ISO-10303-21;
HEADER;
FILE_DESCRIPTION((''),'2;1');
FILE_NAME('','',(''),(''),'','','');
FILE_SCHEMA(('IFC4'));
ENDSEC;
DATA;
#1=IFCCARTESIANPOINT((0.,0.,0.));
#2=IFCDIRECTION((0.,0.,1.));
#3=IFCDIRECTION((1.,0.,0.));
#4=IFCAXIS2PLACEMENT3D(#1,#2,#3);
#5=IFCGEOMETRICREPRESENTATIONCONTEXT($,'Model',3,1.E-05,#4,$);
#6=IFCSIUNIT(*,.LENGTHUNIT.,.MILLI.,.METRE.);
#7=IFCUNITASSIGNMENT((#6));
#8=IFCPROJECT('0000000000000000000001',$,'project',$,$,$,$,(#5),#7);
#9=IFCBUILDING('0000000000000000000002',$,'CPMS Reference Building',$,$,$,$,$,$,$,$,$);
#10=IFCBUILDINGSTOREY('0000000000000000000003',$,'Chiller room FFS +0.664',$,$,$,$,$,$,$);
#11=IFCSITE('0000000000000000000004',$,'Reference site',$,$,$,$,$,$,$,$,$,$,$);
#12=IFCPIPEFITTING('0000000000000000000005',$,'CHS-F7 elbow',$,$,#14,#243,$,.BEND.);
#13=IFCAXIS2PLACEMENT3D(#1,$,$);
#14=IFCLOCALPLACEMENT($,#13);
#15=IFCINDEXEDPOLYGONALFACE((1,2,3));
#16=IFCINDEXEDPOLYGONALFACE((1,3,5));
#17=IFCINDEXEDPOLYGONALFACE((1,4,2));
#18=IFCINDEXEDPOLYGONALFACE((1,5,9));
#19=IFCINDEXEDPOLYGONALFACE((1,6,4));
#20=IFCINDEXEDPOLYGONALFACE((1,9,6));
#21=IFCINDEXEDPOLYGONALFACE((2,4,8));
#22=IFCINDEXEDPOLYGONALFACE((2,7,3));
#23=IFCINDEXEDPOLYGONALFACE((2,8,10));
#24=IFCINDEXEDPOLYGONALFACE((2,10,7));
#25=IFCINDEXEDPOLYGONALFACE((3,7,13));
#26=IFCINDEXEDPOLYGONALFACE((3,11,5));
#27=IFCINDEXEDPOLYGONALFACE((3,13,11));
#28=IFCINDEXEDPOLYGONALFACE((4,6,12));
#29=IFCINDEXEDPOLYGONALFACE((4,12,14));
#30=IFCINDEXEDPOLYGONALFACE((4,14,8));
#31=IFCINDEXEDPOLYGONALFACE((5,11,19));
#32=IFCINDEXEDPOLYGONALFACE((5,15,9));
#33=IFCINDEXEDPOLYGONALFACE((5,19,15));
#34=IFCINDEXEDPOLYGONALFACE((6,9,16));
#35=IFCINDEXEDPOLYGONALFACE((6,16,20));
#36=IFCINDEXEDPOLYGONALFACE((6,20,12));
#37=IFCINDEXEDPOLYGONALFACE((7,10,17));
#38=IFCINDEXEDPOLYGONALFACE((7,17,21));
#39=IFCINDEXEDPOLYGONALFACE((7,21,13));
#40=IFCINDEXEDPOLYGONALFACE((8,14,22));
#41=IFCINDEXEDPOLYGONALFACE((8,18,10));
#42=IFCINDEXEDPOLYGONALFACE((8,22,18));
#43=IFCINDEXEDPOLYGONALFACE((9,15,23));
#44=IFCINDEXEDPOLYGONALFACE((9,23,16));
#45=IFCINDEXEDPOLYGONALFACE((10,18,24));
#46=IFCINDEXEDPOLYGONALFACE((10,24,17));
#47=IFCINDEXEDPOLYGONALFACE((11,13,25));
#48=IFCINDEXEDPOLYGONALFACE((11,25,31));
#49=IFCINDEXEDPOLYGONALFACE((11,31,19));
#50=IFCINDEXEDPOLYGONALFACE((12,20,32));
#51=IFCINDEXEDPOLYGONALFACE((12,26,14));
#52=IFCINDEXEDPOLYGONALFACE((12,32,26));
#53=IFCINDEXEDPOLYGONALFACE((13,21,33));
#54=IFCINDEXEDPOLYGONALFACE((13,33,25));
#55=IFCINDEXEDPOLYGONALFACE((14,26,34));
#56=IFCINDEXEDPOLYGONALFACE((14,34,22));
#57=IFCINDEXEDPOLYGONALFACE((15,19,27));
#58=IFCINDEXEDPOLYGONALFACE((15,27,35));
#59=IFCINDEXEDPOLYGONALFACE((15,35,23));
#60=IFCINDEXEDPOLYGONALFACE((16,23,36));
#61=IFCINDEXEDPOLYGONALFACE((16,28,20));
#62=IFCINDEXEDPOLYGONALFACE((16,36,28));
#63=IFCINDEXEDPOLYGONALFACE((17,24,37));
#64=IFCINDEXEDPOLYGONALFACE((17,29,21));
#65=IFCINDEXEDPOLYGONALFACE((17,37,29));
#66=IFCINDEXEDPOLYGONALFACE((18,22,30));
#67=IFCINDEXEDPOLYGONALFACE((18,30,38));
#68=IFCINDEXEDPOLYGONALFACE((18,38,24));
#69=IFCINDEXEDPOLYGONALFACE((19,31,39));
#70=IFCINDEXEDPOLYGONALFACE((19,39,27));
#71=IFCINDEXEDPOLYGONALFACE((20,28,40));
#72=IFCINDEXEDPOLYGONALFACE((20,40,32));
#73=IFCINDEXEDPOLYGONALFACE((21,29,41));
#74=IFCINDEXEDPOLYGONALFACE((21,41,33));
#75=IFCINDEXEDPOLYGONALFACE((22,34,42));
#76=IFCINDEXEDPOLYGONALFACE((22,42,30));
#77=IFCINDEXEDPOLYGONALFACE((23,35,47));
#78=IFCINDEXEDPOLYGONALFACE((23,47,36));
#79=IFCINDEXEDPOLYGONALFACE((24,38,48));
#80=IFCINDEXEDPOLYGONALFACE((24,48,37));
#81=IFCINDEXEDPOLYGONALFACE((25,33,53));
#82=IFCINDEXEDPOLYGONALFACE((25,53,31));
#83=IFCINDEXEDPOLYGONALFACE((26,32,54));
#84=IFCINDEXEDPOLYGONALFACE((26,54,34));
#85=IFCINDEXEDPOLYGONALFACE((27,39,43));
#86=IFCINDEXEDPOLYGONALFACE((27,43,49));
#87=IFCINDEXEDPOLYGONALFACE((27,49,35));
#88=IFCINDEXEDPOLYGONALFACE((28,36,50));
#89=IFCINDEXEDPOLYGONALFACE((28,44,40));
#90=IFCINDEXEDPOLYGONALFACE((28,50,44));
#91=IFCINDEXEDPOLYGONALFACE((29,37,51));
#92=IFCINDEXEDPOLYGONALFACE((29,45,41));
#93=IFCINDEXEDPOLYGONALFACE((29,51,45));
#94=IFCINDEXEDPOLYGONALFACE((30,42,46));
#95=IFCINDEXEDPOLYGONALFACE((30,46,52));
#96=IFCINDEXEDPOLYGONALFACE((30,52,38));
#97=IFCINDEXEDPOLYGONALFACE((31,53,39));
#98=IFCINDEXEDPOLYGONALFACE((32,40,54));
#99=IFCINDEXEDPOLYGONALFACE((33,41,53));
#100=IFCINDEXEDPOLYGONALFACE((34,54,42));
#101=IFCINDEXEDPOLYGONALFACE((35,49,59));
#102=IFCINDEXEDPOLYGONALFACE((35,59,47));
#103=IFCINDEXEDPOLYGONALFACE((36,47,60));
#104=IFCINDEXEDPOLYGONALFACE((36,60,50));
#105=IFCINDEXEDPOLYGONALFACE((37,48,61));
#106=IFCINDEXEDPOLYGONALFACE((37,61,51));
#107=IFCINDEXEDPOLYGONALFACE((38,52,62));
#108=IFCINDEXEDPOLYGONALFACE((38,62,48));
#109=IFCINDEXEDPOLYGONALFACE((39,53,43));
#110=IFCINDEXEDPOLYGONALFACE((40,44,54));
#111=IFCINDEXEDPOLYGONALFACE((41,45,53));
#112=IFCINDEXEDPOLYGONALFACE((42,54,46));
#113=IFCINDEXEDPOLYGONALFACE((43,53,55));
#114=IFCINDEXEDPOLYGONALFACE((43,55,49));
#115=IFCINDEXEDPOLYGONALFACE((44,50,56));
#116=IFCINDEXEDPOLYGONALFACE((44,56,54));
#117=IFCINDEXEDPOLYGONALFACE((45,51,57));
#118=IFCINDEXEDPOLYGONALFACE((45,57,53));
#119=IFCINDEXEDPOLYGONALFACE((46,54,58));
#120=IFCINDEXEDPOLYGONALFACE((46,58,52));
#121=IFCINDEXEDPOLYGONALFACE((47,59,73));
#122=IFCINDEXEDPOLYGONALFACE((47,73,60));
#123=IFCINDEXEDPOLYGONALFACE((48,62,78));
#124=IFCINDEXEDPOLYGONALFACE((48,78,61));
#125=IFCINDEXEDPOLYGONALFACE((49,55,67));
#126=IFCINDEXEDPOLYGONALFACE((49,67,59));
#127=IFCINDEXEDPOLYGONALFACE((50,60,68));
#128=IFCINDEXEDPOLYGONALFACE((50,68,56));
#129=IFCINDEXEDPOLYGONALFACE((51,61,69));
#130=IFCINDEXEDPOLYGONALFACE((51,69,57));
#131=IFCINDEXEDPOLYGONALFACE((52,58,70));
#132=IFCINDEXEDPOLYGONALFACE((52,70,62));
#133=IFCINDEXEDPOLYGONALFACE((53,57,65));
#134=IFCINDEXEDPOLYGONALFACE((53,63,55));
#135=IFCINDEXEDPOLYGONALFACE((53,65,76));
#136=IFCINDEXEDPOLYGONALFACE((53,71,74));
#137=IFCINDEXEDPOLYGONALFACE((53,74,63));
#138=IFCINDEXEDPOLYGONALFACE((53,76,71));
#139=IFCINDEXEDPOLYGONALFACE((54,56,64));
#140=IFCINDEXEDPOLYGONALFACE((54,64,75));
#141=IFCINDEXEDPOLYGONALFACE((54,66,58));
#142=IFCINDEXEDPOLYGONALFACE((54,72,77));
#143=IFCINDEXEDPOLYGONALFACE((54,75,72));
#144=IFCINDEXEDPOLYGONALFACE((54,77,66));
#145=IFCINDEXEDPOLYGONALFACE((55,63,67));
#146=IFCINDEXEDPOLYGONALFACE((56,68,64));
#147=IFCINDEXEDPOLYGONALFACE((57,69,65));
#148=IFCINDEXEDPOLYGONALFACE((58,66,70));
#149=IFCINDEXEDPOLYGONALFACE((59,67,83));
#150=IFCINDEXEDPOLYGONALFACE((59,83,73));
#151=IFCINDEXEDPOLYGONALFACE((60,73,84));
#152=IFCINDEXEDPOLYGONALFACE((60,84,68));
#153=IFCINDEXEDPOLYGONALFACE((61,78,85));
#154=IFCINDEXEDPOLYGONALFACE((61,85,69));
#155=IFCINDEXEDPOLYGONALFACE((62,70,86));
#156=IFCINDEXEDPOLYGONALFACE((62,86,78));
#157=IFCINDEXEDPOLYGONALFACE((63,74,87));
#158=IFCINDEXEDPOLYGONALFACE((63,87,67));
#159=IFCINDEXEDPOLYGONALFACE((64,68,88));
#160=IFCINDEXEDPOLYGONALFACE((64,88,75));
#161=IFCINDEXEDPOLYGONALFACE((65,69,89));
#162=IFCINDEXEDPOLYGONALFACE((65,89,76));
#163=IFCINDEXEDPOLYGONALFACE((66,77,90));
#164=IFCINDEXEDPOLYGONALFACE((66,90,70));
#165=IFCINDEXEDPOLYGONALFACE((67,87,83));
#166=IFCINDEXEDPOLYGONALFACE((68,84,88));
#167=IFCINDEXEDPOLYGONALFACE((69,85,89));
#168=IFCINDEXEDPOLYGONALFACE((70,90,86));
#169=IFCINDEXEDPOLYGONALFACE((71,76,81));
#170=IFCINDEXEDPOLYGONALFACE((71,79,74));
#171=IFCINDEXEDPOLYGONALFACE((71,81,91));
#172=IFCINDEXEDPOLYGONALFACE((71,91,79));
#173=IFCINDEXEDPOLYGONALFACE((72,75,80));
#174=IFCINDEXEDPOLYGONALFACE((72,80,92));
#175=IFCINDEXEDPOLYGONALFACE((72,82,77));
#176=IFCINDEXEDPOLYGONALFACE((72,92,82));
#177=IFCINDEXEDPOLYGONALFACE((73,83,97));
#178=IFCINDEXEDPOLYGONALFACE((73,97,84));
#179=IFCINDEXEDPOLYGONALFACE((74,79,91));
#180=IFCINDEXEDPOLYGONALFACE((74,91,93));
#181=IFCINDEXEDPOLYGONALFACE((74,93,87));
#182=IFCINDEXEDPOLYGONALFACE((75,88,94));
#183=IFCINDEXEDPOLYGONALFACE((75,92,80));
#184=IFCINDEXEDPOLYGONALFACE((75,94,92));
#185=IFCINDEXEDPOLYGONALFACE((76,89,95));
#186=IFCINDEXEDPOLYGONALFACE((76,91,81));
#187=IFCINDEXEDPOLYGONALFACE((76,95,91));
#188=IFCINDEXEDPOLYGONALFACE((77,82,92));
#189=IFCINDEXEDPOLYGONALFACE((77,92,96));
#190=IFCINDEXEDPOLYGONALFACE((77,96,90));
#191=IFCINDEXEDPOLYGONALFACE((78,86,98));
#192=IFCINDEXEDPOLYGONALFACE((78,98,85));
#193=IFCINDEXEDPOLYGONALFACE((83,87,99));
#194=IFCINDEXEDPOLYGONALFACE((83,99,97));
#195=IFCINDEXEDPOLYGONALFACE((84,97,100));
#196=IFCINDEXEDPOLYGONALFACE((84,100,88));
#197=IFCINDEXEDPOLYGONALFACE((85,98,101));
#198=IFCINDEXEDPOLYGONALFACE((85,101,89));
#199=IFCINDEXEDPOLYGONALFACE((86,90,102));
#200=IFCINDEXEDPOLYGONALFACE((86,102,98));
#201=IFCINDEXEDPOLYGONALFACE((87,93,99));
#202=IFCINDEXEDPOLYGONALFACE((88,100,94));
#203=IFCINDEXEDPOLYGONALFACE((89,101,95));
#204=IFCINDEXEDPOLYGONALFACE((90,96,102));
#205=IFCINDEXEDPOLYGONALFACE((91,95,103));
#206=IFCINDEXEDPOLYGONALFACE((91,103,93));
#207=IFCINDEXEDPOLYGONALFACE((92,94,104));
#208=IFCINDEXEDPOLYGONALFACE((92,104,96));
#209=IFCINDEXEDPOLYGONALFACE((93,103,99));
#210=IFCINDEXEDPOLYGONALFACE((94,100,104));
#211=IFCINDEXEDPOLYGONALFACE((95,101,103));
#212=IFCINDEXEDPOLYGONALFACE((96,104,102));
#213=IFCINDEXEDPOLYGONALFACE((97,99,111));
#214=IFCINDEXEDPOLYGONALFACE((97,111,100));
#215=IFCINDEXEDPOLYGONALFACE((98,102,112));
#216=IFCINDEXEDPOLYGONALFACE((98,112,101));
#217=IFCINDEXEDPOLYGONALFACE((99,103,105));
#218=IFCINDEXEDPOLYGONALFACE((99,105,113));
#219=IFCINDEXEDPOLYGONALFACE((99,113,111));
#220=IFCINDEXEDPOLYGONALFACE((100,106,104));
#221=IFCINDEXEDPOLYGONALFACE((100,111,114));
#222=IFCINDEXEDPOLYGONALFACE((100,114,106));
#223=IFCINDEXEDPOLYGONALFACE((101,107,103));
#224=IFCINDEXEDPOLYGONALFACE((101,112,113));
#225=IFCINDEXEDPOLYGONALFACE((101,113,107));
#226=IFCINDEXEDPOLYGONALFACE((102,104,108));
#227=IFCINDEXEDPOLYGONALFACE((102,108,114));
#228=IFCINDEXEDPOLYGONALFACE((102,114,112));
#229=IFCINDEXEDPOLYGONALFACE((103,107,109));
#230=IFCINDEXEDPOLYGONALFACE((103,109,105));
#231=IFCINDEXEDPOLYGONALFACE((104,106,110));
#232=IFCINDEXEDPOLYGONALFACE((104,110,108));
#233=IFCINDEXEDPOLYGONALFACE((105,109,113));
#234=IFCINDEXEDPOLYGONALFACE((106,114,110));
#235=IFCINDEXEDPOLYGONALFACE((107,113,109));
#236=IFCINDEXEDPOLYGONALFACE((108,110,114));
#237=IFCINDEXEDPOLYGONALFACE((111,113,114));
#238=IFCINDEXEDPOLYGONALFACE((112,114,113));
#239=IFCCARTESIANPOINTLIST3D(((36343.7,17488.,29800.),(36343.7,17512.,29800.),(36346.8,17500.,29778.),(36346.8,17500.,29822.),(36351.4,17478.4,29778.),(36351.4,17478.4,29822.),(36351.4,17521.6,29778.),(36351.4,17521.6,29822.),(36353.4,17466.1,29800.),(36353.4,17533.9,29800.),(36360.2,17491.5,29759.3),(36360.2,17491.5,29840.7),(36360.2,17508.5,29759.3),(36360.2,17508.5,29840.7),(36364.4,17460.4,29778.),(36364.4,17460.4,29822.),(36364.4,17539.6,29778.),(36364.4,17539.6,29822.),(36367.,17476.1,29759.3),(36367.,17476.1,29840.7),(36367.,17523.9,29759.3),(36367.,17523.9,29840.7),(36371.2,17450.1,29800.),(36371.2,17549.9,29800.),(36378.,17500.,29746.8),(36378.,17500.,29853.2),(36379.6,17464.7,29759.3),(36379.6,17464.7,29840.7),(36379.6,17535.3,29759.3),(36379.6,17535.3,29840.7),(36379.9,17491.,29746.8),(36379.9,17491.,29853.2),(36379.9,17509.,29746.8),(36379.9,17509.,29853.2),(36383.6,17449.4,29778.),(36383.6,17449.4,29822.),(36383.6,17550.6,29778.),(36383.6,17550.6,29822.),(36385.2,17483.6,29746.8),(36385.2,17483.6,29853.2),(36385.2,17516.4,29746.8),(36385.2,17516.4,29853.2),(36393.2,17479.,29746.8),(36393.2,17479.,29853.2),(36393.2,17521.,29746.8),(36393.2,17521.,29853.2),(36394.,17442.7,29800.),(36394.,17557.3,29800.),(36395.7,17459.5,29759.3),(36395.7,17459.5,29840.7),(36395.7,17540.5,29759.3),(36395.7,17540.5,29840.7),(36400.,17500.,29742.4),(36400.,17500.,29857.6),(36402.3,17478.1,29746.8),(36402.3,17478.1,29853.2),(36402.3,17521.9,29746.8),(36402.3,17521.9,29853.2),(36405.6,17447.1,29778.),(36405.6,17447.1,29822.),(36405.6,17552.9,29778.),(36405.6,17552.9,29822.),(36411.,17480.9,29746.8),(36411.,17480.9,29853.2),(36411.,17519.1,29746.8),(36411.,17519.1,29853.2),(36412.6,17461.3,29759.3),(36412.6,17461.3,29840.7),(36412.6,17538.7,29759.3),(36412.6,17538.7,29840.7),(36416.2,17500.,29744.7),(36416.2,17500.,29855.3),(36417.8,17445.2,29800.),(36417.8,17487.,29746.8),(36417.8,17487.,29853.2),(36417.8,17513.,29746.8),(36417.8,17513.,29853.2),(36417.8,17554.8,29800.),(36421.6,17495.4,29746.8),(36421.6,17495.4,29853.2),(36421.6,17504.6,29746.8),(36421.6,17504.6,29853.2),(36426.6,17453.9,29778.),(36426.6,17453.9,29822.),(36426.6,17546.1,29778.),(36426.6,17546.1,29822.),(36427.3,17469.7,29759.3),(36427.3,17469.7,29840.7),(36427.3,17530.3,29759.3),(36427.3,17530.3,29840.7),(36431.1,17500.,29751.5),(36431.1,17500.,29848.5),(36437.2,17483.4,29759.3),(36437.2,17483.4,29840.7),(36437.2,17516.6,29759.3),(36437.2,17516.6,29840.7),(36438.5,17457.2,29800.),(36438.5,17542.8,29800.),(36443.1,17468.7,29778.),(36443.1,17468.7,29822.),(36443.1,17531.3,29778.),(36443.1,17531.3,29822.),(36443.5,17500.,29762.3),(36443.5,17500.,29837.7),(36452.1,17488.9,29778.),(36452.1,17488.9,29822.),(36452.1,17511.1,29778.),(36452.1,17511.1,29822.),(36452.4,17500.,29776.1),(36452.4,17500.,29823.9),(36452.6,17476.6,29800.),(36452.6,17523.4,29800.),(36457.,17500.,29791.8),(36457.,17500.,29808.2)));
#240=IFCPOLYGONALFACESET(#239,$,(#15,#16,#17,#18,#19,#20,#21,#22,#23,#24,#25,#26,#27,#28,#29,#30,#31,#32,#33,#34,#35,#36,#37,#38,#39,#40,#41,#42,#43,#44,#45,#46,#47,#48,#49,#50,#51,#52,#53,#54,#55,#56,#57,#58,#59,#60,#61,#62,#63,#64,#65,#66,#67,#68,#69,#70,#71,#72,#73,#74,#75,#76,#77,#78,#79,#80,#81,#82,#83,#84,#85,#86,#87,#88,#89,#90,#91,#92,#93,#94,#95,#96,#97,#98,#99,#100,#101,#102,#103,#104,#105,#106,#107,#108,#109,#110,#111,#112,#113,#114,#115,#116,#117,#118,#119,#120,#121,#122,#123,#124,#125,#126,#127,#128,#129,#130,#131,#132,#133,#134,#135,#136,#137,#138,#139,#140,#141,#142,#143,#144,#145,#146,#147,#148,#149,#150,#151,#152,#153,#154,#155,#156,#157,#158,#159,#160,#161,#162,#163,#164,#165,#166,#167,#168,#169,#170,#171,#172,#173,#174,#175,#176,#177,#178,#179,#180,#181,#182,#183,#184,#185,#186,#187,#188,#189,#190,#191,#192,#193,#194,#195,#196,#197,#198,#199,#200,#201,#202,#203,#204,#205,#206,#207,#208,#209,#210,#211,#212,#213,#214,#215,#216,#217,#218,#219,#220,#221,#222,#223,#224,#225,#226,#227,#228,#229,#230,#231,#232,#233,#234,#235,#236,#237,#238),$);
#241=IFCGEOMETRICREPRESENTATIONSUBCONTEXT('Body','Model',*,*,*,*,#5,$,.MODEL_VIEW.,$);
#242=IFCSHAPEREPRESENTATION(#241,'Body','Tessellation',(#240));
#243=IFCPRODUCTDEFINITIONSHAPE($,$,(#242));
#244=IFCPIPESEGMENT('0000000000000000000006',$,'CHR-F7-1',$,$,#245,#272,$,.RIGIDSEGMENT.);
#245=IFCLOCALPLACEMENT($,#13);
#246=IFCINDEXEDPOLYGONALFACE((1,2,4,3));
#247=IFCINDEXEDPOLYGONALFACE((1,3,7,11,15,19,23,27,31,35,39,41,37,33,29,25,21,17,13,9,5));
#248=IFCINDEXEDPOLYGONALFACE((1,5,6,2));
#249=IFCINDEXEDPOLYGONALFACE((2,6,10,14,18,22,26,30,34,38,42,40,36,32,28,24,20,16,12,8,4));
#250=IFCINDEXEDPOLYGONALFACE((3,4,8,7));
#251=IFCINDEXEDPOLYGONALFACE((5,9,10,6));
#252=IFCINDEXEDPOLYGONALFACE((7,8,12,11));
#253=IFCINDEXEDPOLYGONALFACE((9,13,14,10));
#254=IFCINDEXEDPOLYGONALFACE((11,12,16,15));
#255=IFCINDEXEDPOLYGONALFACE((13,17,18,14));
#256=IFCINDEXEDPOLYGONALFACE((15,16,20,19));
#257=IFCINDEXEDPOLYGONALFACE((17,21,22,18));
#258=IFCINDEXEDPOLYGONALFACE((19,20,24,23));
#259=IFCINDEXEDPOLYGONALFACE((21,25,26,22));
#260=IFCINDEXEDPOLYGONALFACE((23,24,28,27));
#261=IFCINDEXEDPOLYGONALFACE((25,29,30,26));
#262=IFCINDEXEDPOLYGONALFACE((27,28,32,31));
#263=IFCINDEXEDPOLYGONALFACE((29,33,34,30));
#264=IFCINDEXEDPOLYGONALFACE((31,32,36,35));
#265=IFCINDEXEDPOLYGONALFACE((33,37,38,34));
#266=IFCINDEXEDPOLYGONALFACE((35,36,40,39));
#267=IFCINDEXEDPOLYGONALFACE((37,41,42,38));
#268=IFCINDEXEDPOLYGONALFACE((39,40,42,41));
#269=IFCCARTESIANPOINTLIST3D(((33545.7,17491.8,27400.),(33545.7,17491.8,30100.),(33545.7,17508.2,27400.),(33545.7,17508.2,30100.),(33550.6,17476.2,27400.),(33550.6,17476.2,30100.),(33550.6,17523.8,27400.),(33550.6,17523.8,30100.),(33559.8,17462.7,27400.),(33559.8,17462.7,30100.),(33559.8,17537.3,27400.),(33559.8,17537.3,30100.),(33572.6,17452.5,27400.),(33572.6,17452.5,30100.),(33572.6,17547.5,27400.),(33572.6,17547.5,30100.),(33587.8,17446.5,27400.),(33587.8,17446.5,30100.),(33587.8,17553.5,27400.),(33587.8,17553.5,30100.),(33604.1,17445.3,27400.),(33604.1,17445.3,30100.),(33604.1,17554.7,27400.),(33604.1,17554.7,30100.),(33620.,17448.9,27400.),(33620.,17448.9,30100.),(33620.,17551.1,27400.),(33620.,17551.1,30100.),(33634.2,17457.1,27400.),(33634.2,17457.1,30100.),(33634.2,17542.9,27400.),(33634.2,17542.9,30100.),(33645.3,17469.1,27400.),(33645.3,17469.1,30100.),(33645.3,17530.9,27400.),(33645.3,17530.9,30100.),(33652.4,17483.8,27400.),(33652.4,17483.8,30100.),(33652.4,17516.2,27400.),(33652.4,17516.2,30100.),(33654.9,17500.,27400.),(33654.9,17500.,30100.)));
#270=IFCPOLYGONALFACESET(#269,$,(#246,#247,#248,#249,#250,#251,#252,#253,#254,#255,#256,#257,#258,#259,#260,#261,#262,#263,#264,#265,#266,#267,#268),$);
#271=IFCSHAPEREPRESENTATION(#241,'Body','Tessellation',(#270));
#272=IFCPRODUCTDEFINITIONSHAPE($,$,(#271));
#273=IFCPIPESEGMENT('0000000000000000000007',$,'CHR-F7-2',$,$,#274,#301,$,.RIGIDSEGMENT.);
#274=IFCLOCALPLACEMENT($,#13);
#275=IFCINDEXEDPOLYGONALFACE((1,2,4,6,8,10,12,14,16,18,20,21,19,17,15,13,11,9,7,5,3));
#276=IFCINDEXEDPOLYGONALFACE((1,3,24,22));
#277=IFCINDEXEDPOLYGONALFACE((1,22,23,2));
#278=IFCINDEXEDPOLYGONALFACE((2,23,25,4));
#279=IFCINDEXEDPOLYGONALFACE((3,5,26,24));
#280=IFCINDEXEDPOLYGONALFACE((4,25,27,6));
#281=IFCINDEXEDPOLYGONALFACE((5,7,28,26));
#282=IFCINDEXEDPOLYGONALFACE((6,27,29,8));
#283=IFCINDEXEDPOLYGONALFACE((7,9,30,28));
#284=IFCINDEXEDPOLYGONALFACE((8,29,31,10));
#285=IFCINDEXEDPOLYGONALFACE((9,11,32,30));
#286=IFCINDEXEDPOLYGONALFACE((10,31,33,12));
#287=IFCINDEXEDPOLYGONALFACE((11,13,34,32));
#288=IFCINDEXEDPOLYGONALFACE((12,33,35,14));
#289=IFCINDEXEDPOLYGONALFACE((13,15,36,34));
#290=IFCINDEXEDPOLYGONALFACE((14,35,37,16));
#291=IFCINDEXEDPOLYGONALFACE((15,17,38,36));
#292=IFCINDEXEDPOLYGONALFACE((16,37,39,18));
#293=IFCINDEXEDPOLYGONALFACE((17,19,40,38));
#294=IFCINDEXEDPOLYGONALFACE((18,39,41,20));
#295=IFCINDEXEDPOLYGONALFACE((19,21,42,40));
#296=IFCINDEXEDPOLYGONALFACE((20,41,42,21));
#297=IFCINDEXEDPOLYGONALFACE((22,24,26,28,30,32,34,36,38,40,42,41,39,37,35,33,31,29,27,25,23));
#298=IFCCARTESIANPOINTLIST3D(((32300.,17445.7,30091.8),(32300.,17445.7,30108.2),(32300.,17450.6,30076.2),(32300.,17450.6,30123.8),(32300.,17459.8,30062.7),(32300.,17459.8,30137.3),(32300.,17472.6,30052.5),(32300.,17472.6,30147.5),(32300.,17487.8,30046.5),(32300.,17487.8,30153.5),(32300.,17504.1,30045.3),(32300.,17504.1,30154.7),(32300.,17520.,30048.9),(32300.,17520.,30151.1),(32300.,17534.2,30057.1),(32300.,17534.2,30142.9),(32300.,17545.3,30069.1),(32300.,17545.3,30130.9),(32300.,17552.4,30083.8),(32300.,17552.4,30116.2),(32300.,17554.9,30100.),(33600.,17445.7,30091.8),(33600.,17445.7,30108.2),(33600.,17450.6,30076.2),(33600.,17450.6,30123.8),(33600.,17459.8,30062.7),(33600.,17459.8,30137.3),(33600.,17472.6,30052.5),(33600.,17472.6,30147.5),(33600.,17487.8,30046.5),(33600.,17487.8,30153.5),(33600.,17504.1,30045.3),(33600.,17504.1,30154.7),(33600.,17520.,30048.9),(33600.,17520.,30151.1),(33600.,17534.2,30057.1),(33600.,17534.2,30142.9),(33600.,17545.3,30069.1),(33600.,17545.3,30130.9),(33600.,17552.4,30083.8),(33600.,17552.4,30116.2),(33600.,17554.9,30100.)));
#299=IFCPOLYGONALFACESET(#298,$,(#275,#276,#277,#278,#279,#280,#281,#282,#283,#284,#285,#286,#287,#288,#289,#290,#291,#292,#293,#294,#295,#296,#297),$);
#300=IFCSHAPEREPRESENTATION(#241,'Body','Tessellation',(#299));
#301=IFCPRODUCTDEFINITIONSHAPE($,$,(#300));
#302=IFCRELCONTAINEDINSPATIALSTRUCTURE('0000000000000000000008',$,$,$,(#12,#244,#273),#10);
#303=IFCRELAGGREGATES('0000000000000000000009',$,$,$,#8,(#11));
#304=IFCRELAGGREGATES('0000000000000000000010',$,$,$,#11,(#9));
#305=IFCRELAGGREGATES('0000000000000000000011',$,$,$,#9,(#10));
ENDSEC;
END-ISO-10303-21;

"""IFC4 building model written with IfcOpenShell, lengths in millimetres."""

from ifc_helpers import new_model, entity, si_unit, frame, origin_with_axes, origin_2d, place, context, subcontext, project, spatial, circle_curve, outline, extrude, element, save


model = new_model("IFC4")

# Units and contexts
model_context = context("Model", 3, precision=1e-05, world=origin_with_axes())
body_context = subcontext(model_context, "Body", "Model", "MODEL_VIEW")
ifc_project = project(units=[si_unit("LENGTHUNIT", "METRE", prefix="MILLI")], contexts=[model_context])

# Site, building, storey
site = spatial("IfcSite", under=ifc_project, Name="Reference site")
building = spatial("IfcBuilding", under=site, Name="CPMS Reference Building")
storey = spatial("IfcBuildingStorey", under=building, Name="Chiller room FFS +0.664")

# Pipe fitting
pipe_fitting_1_placement = place(None, origin_with_axes())
element("IfcPipeFitting", 1, at=pipe_fitting_1_placement, inside=storey, Name="CHS-F7 elbow", PredefinedType="BEND", context=body_context, shape_type="CSG", body=[
    entity("IfcSphere", entity("IfcAxis2Placement3D", entity("IfcCartesianPoint", [36400.0, 17500.0, 29800.0]), entity("IfcDirection", [0.0, 0.0, 1.0]), entity("IfcDirection", [1.0, 0.0, 0.0])), 57.6),
])

# Pipe segments
pipe_segment_1_placement = place(None, origin_with_axes())
element("IfcPipeSegment", 2, at=pipe_segment_1_placement, inside=storey, Name="CHR-F7-1", PredefinedType="RIGIDSEGMENT", context=body_context, shape_type="SweptSolid", body=[
    extrude(outline(circle_curve(origin_2d(), 54.9)), frame((33600.0, 17500.0, 27400.0), z_axis=(0.0, 0.0, 1.0), x_axis=(1.0, 0.0, 0.0)), (0.0, 0.0, 1.0), 2700.0),
])
pipe_segment_2_placement = place(None, origin_with_axes())
element("IfcPipeSegment", 3, at=pipe_segment_2_placement, inside=storey, Name="CHR-F7-2", PredefinedType="RIGIDSEGMENT", context=body_context, shape_type="SweptSolid", body=[
    extrude(outline(circle_curve(origin_2d(), 54.9)), frame((33600.0, 17500.0, 30100.0), z_axis=(-1.0, 0.0, 0.0), x_axis=(0.0, 1.0, 0.0)), (0.0, 0.0, 1.0), 1300.0),
])

save(model, "model.ifc")
